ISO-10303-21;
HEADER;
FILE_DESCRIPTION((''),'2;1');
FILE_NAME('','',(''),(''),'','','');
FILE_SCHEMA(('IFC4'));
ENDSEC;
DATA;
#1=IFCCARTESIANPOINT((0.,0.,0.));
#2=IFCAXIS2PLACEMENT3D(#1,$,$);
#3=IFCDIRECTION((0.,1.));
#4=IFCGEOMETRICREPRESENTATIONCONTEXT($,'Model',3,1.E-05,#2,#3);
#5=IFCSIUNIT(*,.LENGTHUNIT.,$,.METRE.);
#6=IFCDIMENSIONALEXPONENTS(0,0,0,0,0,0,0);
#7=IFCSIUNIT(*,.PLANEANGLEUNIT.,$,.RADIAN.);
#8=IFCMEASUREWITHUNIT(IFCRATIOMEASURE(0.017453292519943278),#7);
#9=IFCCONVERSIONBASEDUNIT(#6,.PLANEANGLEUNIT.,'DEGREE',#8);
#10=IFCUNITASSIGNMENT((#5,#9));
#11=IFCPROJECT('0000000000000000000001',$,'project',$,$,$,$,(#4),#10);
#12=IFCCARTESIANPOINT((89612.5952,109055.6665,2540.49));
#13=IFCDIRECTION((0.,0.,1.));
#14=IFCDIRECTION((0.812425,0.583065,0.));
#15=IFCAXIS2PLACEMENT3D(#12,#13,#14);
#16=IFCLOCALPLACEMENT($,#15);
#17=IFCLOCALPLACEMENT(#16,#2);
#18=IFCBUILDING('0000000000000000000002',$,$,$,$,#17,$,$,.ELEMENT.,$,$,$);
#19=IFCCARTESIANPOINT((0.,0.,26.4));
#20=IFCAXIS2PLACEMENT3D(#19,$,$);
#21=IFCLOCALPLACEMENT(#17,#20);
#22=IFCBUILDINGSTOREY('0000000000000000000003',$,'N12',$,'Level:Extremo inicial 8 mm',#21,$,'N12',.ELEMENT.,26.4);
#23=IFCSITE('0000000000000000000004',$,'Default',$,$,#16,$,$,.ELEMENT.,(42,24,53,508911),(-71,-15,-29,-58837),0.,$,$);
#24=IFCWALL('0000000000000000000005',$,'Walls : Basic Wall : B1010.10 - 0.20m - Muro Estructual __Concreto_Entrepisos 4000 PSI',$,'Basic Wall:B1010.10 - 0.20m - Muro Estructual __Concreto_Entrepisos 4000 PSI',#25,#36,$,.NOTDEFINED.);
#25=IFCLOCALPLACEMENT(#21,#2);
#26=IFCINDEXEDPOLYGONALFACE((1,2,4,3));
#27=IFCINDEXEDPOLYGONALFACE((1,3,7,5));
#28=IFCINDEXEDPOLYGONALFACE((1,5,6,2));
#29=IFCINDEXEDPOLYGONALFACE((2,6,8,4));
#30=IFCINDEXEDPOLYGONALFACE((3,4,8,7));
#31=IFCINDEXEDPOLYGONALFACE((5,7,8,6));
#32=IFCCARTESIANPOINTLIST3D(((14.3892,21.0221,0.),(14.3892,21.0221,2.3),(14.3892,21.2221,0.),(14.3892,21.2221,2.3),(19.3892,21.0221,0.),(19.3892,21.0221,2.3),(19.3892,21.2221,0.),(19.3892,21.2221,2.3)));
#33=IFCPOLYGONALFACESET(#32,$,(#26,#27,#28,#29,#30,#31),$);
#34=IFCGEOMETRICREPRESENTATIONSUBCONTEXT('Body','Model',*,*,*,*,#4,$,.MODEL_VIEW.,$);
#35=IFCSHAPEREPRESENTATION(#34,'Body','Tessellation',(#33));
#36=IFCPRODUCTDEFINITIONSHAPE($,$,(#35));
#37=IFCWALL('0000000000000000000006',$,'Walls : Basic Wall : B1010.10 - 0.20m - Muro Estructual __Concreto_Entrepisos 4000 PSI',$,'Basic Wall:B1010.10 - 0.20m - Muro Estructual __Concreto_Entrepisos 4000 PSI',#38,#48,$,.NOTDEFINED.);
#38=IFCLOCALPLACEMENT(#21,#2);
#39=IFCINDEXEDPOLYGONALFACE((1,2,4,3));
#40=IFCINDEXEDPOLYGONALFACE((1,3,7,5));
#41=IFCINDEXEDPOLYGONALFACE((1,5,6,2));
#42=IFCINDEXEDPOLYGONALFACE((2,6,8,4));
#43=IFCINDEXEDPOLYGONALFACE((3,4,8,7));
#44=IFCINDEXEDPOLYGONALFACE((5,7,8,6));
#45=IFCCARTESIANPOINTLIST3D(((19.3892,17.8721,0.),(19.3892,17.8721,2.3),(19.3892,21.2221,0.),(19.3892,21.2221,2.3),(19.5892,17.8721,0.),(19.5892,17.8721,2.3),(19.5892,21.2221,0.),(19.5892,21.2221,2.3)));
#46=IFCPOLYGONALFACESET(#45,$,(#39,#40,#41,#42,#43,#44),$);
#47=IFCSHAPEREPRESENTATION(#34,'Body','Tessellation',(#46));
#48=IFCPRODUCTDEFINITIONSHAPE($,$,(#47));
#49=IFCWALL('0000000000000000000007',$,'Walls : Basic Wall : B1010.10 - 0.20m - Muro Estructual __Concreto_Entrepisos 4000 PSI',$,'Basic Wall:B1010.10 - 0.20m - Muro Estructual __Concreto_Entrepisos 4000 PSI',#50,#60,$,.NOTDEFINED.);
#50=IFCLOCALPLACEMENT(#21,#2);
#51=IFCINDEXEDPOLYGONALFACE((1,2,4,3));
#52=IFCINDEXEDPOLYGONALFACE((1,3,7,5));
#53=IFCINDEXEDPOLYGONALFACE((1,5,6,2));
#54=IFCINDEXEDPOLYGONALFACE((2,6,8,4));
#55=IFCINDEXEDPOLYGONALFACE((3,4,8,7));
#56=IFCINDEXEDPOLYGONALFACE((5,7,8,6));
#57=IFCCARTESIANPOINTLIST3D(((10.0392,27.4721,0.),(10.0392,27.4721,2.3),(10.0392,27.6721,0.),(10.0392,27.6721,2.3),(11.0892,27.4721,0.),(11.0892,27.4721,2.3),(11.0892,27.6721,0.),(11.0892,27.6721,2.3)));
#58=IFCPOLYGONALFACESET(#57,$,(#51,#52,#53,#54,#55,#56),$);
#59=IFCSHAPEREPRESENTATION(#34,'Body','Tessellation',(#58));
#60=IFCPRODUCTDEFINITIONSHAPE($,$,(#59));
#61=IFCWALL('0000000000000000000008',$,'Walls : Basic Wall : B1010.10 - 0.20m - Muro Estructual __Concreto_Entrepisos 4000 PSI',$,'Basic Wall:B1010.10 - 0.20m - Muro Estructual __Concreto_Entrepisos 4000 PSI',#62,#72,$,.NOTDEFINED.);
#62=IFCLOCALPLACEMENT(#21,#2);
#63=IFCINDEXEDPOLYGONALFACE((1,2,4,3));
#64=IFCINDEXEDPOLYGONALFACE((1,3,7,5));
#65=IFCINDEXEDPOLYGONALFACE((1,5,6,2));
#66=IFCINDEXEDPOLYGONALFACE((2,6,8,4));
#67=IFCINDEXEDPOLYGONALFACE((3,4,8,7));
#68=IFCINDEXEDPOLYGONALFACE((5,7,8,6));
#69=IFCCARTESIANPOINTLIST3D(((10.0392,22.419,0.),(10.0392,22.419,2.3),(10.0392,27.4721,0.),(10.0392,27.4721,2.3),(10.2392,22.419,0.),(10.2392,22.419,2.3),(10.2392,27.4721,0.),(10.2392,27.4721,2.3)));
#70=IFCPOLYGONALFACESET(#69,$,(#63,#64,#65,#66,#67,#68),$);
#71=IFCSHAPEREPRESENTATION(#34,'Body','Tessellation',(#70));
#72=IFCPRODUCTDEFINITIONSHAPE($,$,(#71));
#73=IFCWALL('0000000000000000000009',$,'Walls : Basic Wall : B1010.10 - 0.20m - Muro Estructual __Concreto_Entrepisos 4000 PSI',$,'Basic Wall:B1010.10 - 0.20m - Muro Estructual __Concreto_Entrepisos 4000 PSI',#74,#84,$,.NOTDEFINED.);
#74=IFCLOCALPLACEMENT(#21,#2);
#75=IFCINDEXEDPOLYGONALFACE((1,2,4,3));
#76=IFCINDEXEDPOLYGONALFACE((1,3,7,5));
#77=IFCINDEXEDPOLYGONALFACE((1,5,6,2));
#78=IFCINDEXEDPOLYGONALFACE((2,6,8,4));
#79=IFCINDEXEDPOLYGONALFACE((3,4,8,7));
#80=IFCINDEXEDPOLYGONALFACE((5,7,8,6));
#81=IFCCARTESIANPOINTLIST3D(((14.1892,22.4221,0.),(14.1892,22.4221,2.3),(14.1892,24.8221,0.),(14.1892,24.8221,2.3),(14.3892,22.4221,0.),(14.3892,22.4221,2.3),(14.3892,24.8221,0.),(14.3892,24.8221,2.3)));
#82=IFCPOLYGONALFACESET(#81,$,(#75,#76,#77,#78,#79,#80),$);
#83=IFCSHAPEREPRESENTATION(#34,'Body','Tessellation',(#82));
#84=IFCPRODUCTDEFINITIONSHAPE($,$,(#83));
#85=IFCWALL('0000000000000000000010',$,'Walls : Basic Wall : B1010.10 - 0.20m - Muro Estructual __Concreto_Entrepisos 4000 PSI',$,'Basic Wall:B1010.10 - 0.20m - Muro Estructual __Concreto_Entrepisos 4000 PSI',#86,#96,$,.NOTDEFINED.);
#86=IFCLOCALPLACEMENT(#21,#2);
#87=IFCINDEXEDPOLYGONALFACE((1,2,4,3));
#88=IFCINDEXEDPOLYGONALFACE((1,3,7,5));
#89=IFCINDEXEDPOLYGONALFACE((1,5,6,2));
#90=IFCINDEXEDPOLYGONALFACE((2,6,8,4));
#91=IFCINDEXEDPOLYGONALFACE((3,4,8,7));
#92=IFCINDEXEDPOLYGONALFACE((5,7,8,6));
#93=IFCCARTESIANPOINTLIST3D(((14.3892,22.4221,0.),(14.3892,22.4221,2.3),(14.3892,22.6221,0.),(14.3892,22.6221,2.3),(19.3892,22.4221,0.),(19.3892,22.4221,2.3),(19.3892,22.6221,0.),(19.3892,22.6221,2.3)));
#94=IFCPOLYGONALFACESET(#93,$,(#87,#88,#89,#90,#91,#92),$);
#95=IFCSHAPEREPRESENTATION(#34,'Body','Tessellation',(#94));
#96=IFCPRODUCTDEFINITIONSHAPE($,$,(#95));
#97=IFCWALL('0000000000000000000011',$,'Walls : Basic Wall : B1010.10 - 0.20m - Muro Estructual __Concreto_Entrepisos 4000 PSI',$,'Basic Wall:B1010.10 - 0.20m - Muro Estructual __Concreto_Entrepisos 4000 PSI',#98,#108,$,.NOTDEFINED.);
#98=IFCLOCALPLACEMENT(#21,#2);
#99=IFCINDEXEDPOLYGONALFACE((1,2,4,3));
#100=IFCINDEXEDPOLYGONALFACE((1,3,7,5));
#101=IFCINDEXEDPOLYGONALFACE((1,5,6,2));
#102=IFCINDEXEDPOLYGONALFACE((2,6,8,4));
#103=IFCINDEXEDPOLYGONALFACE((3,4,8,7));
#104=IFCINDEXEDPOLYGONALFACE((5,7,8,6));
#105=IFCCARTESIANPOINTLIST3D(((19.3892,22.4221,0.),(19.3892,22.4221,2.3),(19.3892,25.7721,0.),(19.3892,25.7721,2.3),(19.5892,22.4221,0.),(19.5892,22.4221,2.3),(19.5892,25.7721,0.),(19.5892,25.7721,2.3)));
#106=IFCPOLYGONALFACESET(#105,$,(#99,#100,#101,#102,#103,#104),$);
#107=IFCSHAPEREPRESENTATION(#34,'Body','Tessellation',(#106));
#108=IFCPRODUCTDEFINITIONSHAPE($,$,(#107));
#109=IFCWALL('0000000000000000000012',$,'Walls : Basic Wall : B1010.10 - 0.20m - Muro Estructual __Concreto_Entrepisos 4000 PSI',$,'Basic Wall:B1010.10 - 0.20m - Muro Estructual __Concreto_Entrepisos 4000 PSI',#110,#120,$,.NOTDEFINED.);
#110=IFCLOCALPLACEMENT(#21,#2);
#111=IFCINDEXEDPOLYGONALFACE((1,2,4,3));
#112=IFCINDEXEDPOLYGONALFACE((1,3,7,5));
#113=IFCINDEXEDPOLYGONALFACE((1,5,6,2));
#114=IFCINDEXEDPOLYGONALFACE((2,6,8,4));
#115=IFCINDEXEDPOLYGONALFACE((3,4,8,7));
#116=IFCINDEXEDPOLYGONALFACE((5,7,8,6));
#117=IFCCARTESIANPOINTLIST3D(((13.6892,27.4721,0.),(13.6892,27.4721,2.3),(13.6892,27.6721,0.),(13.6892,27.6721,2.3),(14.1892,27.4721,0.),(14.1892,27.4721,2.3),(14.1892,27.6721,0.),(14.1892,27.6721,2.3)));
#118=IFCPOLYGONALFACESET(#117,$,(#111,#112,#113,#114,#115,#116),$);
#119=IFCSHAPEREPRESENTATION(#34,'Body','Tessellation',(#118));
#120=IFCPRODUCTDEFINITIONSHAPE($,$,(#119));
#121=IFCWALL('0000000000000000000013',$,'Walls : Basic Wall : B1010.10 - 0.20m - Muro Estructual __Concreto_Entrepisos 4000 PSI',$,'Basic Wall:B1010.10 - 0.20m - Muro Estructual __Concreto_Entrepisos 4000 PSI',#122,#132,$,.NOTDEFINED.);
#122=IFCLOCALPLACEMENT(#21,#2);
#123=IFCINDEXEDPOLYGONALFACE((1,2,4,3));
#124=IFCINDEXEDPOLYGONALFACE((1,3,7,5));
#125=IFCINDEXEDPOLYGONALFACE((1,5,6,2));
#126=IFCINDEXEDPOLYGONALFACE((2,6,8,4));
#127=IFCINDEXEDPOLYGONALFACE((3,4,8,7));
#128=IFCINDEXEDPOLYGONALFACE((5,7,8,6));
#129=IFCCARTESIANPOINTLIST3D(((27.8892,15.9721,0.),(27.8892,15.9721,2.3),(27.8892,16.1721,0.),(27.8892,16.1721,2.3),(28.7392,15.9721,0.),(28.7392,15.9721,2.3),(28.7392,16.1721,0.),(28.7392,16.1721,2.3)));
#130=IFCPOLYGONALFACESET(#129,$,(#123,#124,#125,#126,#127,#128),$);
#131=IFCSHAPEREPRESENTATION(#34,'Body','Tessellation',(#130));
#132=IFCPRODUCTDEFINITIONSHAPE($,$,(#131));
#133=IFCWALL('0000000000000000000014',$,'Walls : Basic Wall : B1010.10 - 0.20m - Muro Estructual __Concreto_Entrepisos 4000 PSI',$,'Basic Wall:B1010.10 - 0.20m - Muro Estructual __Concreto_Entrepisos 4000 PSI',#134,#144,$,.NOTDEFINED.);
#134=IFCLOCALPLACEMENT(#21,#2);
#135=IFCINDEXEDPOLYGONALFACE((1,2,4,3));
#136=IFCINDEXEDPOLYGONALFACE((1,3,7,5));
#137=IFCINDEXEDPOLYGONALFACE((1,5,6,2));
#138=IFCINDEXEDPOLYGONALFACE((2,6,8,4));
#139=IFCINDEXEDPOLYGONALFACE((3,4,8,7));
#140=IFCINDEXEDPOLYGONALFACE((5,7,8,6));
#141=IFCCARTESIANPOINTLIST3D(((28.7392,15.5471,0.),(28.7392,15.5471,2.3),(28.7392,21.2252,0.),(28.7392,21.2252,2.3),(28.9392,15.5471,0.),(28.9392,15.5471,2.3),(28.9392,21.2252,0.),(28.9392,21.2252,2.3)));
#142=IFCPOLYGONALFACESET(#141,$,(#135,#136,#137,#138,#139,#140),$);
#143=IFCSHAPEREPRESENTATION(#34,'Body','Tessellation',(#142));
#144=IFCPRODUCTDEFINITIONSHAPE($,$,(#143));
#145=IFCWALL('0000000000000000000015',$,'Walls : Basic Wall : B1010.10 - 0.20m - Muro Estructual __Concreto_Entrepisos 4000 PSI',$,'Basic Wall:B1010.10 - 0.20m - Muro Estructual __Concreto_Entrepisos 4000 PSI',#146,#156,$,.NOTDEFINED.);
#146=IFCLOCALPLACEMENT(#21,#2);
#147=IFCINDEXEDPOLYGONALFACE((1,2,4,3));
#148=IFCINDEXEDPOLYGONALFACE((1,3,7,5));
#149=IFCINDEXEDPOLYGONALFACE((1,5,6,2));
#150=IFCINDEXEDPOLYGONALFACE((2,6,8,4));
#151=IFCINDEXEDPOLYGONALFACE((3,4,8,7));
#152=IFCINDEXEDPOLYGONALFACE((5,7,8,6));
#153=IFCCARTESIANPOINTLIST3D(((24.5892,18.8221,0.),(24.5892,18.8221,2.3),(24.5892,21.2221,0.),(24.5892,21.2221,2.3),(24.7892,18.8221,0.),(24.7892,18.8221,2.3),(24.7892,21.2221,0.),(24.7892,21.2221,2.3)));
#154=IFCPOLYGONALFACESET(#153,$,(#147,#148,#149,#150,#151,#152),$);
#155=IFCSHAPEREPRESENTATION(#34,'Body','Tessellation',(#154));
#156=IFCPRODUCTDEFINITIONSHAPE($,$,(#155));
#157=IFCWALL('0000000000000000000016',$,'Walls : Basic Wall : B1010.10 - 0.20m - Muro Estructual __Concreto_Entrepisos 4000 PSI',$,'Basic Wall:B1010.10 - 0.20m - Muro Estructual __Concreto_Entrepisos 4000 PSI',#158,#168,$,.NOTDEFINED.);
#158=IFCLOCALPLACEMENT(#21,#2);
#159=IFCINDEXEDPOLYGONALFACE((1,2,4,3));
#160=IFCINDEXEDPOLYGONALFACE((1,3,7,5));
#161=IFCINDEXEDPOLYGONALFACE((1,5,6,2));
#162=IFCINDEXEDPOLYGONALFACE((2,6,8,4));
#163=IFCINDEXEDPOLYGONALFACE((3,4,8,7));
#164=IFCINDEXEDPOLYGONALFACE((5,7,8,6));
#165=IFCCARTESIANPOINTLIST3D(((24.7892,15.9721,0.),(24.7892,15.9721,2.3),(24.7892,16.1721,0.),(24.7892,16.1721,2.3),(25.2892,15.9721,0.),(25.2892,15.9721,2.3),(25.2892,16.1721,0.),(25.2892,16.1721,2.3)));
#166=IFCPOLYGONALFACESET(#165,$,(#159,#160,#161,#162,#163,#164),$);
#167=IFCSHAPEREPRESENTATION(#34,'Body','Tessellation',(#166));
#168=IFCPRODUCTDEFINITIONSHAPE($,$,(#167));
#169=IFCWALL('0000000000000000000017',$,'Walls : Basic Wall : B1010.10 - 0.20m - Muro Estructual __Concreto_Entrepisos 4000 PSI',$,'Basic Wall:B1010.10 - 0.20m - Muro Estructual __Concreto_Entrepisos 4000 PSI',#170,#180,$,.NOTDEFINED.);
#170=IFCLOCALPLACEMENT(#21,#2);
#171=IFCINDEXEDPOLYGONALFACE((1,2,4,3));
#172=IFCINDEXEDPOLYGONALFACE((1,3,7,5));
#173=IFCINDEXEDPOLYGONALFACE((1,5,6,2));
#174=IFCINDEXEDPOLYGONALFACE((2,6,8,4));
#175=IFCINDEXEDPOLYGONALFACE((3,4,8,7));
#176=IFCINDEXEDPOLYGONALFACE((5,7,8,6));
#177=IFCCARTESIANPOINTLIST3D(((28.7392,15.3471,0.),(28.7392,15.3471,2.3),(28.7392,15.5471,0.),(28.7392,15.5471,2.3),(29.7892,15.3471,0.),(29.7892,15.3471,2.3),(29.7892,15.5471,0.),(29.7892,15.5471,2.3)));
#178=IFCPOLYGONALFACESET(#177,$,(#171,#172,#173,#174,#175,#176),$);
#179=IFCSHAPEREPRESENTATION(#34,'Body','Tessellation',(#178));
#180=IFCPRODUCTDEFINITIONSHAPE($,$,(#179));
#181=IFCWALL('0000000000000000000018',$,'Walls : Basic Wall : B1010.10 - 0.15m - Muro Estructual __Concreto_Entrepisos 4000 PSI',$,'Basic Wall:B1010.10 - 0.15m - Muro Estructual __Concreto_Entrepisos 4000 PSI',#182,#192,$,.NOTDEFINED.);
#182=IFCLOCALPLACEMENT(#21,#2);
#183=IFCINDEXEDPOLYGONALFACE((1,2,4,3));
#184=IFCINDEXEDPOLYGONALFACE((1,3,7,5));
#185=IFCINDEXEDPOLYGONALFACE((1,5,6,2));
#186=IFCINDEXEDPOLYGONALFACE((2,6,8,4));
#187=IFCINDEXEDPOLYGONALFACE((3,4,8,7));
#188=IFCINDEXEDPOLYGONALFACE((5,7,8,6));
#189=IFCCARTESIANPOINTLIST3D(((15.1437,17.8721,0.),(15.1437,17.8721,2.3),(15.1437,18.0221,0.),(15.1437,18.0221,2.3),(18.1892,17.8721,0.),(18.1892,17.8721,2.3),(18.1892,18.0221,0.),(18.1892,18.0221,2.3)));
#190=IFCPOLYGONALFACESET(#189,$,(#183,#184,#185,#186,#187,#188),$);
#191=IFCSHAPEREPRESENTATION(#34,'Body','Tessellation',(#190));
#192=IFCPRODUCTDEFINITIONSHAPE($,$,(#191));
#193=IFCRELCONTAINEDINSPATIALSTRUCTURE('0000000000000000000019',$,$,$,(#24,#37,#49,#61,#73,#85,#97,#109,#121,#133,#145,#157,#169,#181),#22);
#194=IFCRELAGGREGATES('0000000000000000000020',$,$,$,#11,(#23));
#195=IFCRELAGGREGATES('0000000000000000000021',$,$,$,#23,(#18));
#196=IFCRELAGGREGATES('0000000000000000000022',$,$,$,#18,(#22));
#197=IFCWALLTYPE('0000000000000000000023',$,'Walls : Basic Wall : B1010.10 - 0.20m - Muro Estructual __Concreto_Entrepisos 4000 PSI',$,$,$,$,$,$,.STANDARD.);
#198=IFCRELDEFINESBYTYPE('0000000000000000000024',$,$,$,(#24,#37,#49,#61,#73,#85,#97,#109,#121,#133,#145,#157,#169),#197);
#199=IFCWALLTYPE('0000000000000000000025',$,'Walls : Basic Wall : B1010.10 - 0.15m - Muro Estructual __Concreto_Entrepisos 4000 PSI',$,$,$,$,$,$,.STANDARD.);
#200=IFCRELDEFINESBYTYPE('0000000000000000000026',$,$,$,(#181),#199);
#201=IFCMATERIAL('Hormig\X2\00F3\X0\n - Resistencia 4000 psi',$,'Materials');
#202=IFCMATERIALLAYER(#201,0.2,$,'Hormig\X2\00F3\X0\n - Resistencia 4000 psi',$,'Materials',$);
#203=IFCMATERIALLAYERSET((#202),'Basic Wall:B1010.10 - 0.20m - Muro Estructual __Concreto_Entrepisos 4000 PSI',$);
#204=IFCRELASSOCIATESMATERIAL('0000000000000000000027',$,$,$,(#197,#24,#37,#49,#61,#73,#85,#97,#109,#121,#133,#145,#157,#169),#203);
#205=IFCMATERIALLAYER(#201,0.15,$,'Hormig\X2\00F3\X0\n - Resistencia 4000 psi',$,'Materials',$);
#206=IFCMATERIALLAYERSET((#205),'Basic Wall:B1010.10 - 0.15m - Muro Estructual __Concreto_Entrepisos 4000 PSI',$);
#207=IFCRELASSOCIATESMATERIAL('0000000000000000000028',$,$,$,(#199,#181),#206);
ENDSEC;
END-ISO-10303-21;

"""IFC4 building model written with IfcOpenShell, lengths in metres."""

from ifc_helpers import new_model, entity, si_unit, converted_unit, direction, frame, frame_2d, origin, place, context, subcontext, project, spatial, rectangle, extrude, material, layer, layer_set, layer_usage, type_object, element, save


model = new_model("IFC4")

# Units and contexts
model_context = context("Model", 3, precision=1e-05, world=origin(), true_north=direction((0.0, 1.0)))
body_context = subcontext(model_context, "Body", "Model", "MODEL_VIEW")
ifc_project = project(units=[si_unit("LENGTHUNIT", "METRE"), converted_unit("PLANEANGLEUNIT", "DEGREE", entity("IfcRatioMeasure", 0.017453292519943278), si_unit("PLANEANGLEUNIT", "RADIAN"), dimensions=[0, 0, 0, 0, 0, 0, 0])], contexts=[model_context])

# Site, building, storey
site_placement = place(None, frame((89612.5952, 109055.6665, 2540.49), z_axis=(0.0, 0.0, 1.0), x_axis=(0.812425, 0.583065, 0.0)))
site = spatial("IfcSite", under=ifc_project, at=site_placement, Name="Default", CompositionType="ELEMENT", RefLatitude=(42, 24, 53, 508911), RefLongitude=(-71, -15, -29, -58837), RefElevation=0.0)
building_placement = place(site_placement, origin())
building = spatial("IfcBuilding", under=site, at=building_placement, CompositionType="ELEMENT")
storey_placement = place(building_placement, frame((0.0, 0.0, 26.4)))
storey = spatial("IfcBuildingStorey", under=building, at=storey_placement, Name="N12", ObjectType="Level:Extremo inicial 8 mm", LongName="N12", CompositionType="ELEMENT", Elevation=26.4)

# Walls
ifc_material = material(Name="Hormigón - Resistencia 4000 psi", Category="Materials")
ifc_layer_1 = layer(ifc_material, 0.2, Name="Hormigón - Resistencia 4000 psi", Category="Materials")
ifc_layer_set_1 = layer_set([ifc_layer_1], Name="Basic Wall:B1010.10 - 0.20m - Muro Estructual __Concreto_Entrepisos 4000 PSI")
ifc_layer_usage_1 = layer_usage(ifc_layer_set_1, "AXIS2", "NEGATIVE", 0.1)
wall_type_1 = type_object("IfcWallType", Name="Walls : Basic Wall : B1010.10 - 0.20m - Muro Estructual __Concreto_Entrepisos 4000 PSI", PredefinedType="STANDARD", material=ifc_layer_set_1)
wall_1_placement = place(storey_placement, frame((14.3892, 21.1221, 0.0)))
element("IfcWall", 1, at=wall_1_placement, inside=storey, type_object=wall_type_1, material=ifc_layer_usage_1, Name="Walls : Basic Wall : B1010.10 - 0.20m - Muro Estructual __Concreto_Entrepisos 4000 PSI", ObjectType="Basic Wall:B1010.10 - 0.20m - Muro Estructual __Concreto_Entrepisos 4000 PSI", PredefinedType="NOTDEFINED", context=body_context, shape_type="SweptSolid", body=[
    extrude(rectangle(XDim=5.0, YDim=0.2, at=frame_2d((2.5, 0.0), x_axis=(-1.0, 0.0))), origin(), (0.0, 0.0, 1.0), 2.3),
])
ifc_layer_usage_2 = layer_usage(ifc_layer_set_1, "AXIS2", "NEGATIVE", 0.1)
wall_2_placement = place(storey_placement, frame((19.4892, 21.2221, 0.0), z_axis=(0.0, 0.0, 1.0), x_axis=(0.0, -1.0, 0.0)))
element("IfcWall", 2, at=wall_2_placement, inside=storey, type_object=wall_type_1, material=ifc_layer_usage_2, Name="Walls : Basic Wall : B1010.10 - 0.20m - Muro Estructual __Concreto_Entrepisos 4000 PSI", ObjectType="Basic Wall:B1010.10 - 0.20m - Muro Estructual __Concreto_Entrepisos 4000 PSI", PredefinedType="NOTDEFINED", context=body_context, shape_type="SweptSolid", body=[
    extrude(rectangle(XDim=3.35, YDim=0.2, at=frame_2d((1.675, 0.0), x_axis=(-1.0, 0.0))), origin(), (0.0, 0.0, 1.0), 2.3),
])
ifc_layer_usage_3 = layer_usage(ifc_layer_set_1, "AXIS2", "POSITIVE", -0.1)
wall_3_placement = place(storey_placement, frame((11.0892, 27.5721, 0.0), z_axis=(0.0, 0.0, 1.0), x_axis=(-1.0, 0.0, 0.0)))
element("IfcWall", 3, at=wall_3_placement, inside=storey, type_object=wall_type_1, material=ifc_layer_usage_3, Name="Walls : Basic Wall : B1010.10 - 0.20m - Muro Estructual __Concreto_Entrepisos 4000 PSI", ObjectType="Basic Wall:B1010.10 - 0.20m - Muro Estructual __Concreto_Entrepisos 4000 PSI", PredefinedType="NOTDEFINED", context=body_context, shape_type="SweptSolid", body=[
    extrude(rectangle(XDim=1.05, YDim=0.2, at=frame_2d((0.525, 0.0), x_axis=(-1.0, 0.0))), origin(), (0.0, 0.0, 1.0), 2.3),
])
ifc_layer_usage_4 = layer_usage(ifc_layer_set_1, "AXIS2", "POSITIVE", -0.1)
wall_4_placement = place(storey_placement, frame((10.1392, 27.4721, 0.0), z_axis=(0.0, 0.0, 1.0), x_axis=(0.0, -1.0, 0.0)))
element("IfcWall", 4, at=wall_4_placement, inside=storey, type_object=wall_type_1, material=ifc_layer_usage_4, Name="Walls : Basic Wall : B1010.10 - 0.20m - Muro Estructual __Concreto_Entrepisos 4000 PSI", ObjectType="Basic Wall:B1010.10 - 0.20m - Muro Estructual __Concreto_Entrepisos 4000 PSI", PredefinedType="NOTDEFINED", context=body_context, shape_type="SweptSolid", body=[
    extrude(rectangle(XDim=5.0531, YDim=0.2, at=frame_2d((2.5265, 0.0), x_axis=(-1.0, 0.0))), origin(), (0.0, 0.0, 1.0), 2.3),
])
ifc_layer_usage_5 = layer_usage(ifc_layer_set_1, "AXIS2", "POSITIVE", -0.1)
wall_5_placement = place(storey_placement, frame((14.2892, 24.8221, 0.0), z_axis=(0.0, 0.0, 1.0), x_axis=(0.0, -1.0, 0.0)))
element("IfcWall", 5, at=wall_5_placement, inside=storey, type_object=wall_type_1, material=ifc_layer_usage_5, Name="Walls : Basic Wall : B1010.10 - 0.20m - Muro Estructual __Concreto_Entrepisos 4000 PSI", ObjectType="Basic Wall:B1010.10 - 0.20m - Muro Estructual __Concreto_Entrepisos 4000 PSI", PredefinedType="NOTDEFINED", context=body_context, shape_type="SweptSolid", body=[
    extrude(rectangle(XDim=2.4, YDim=0.2, at=frame_2d((1.2, 0.0), x_axis=(-1.0, 0.0))), origin(), (0.0, 0.0, 1.0), 2.3),
])
ifc_layer_usage_6 = layer_usage(ifc_layer_set_1, "AXIS2", "POSITIVE", -0.1)
wall_6_placement = place(storey_placement, frame((14.3892, 22.5221, 0.0)))
element("IfcWall", 6, at=wall_6_placement, inside=storey, type_object=wall_type_1, material=ifc_layer_usage_6, Name="Walls : Basic Wall : B1010.10 - 0.20m - Muro Estructual __Concreto_Entrepisos 4000 PSI", ObjectType="Basic Wall:B1010.10 - 0.20m - Muro Estructual __Concreto_Entrepisos 4000 PSI", PredefinedType="NOTDEFINED", context=body_context, shape_type="SweptSolid", body=[
    extrude(rectangle(XDim=5.0, YDim=0.2, at=frame_2d((2.5, 0.0), x_axis=(-1.0, 0.0))), origin(), (0.0, 0.0, 1.0), 2.3),
])
ifc_layer_usage_7 = layer_usage(ifc_layer_set_1, "AXIS2", "POSITIVE", -0.1)
wall_7_placement = place(storey_placement, frame((19.4892, 22.4221, 0.0), z_axis=(0.0, 0.0, 1.0), x_axis=(0.0, 1.0, 0.0)))
element("IfcWall", 7, at=wall_7_placement, inside=storey, type_object=wall_type_1, material=ifc_layer_usage_7, Name="Walls : Basic Wall : B1010.10 - 0.20m - Muro Estructual __Concreto_Entrepisos 4000 PSI", ObjectType="Basic Wall:B1010.10 - 0.20m - Muro Estructual __Concreto_Entrepisos 4000 PSI", PredefinedType="NOTDEFINED", context=body_context, shape_type="SweptSolid", body=[
    extrude(rectangle(XDim=3.35, YDim=0.2, at=frame_2d((1.675, 0.0), x_axis=(-1.0, 0.0))), origin(), (0.0, 0.0, 1.0), 2.3),
])
ifc_layer_usage_8 = layer_usage(ifc_layer_set_1, "AXIS2", "POSITIVE", -0.1)
wall_8_placement = place(storey_placement, frame((13.6892, 27.5721, 0.0)))
element("IfcWall", 8, at=wall_8_placement, inside=storey, type_object=wall_type_1, material=ifc_layer_usage_8, Name="Walls : Basic Wall : B1010.10 - 0.20m - Muro Estructual __Concreto_Entrepisos 4000 PSI", ObjectType="Basic Wall:B1010.10 - 0.20m - Muro Estructual __Concreto_Entrepisos 4000 PSI", PredefinedType="NOTDEFINED", context=body_context, shape_type="SweptSolid", body=[
    extrude(rectangle(XDim=0.5, YDim=0.2, at=frame_2d((0.25, 0.0), x_axis=(-1.0, 0.0))), origin(), (0.0, 0.0, 1.0), 2.3),
])
ifc_layer_usage_9 = layer_usage(ifc_layer_set_1, "AXIS2", "POSITIVE", -0.1)
wall_9_placement = place(storey_placement, frame((27.8892, 16.0721, 0.0)))
element("IfcWall", 9, at=wall_9_placement, inside=storey, type_object=wall_type_1, material=ifc_layer_usage_9, Name="Walls : Basic Wall : B1010.10 - 0.20m - Muro Estructual __Concreto_Entrepisos 4000 PSI", ObjectType="Basic Wall:B1010.10 - 0.20m - Muro Estructual __Concreto_Entrepisos 4000 PSI", PredefinedType="NOTDEFINED", context=body_context, shape_type="SweptSolid", body=[
    extrude(rectangle(XDim=0.85, YDim=0.2, at=frame_2d((0.425, 0.0), x_axis=(-1.0, 0.0))), origin(), (0.0, 0.0, 1.0), 2.3),
])
ifc_layer_usage_10 = layer_usage(ifc_layer_set_1, "AXIS2", "POSITIVE", -0.1)
wall_10_placement = place(storey_placement, frame((28.8392, 15.5471, 0.0), z_axis=(0.0, 0.0, 1.0), x_axis=(0.0, 1.0, 0.0)))
element("IfcWall", 10, at=wall_10_placement, inside=storey, type_object=wall_type_1, material=ifc_layer_usage_10, Name="Walls : Basic Wall : B1010.10 - 0.20m - Muro Estructual __Concreto_Entrepisos 4000 PSI", ObjectType="Basic Wall:B1010.10 - 0.20m - Muro Estructual __Concreto_Entrepisos 4000 PSI", PredefinedType="NOTDEFINED", context=body_context, shape_type="SweptSolid", body=[
    extrude(rectangle(XDim=5.6781, YDim=0.2, at=frame_2d((2.839, 0.0), x_axis=(-1.0, 0.0))), origin(), (0.0, 0.0, 1.0), 2.3),
])
ifc_layer_usage_11 = layer_usage(ifc_layer_set_1, "AXIS2", "POSITIVE", -0.1)
wall_11_placement = place(storey_placement, frame((24.6892, 18.8221, 0.0), z_axis=(0.0, 0.0, 1.0), x_axis=(0.0, 1.0, 0.0)))
element("IfcWall", 11, at=wall_11_placement, inside=storey, type_object=wall_type_1, material=ifc_layer_usage_11, Name="Walls : Basic Wall : B1010.10 - 0.20m - Muro Estructual __Concreto_Entrepisos 4000 PSI", ObjectType="Basic Wall:B1010.10 - 0.20m - Muro Estructual __Concreto_Entrepisos 4000 PSI", PredefinedType="NOTDEFINED", context=body_context, shape_type="SweptSolid", body=[
    extrude(rectangle(XDim=2.4, YDim=0.2, at=frame_2d((1.2, 0.0), x_axis=(-1.0, 0.0))), origin(), (0.0, 0.0, 1.0), 2.3),
])
ifc_layer_usage_12 = layer_usage(ifc_layer_set_1, "AXIS2", "POSITIVE", -0.1)
wall_12_placement = place(storey_placement, frame((25.2892, 16.0721, 0.0), z_axis=(0.0, 0.0, 1.0), x_axis=(-1.0, 0.0, 0.0)))
element("IfcWall", 12, at=wall_12_placement, inside=storey, type_object=wall_type_1, material=ifc_layer_usage_12, Name="Walls : Basic Wall : B1010.10 - 0.20m - Muro Estructual __Concreto_Entrepisos 4000 PSI", ObjectType="Basic Wall:B1010.10 - 0.20m - Muro Estructual __Concreto_Entrepisos 4000 PSI", PredefinedType="NOTDEFINED", context=body_context, shape_type="SweptSolid", body=[
    extrude(rectangle(XDim=0.5, YDim=0.2, at=frame_2d((0.25, 0.0), x_axis=(-1.0, 0.0))), origin(), (0.0, 0.0, 1.0), 2.3),
])
ifc_layer_usage_13 = layer_usage(ifc_layer_set_1, "AXIS2", "NEGATIVE", 0.1)
wall_13_placement = place(storey_placement, frame((29.7892, 15.4471, 0.0), z_axis=(0.0, 0.0, 1.0), x_axis=(-1.0, 0.0, 0.0)))
element("IfcWall", 13, at=wall_13_placement, inside=storey, type_object=wall_type_1, material=ifc_layer_usage_13, Name="Walls : Basic Wall : B1010.10 - 0.20m - Muro Estructual __Concreto_Entrepisos 4000 PSI", ObjectType="Basic Wall:B1010.10 - 0.20m - Muro Estructual __Concreto_Entrepisos 4000 PSI", PredefinedType="NOTDEFINED", context=body_context, shape_type="SweptSolid", body=[
    extrude(rectangle(XDim=1.05, YDim=0.2, at=frame_2d((0.525, 0.0), x_axis=(-1.0, 0.0))), origin(), (0.0, 0.0, 1.0), 2.3),
])
ifc_layer_2 = layer(ifc_material, 0.15, Name="Hormigón - Resistencia 4000 psi", Category="Materials")
ifc_layer_set_2 = layer_set([ifc_layer_2], Name="Basic Wall:B1010.10 - 0.15m - Muro Estructual __Concreto_Entrepisos 4000 PSI")
ifc_layer_usage_14 = layer_usage(ifc_layer_set_2, "AXIS2", "NEGATIVE", 0.075)
wall_type_2 = type_object("IfcWallType", Name="Walls : Basic Wall : B1010.10 - 0.15m - Muro Estructual __Concreto_Entrepisos 4000 PSI", PredefinedType="STANDARD", material=ifc_layer_set_2)
wall_14_placement = place(storey_placement, frame((18.1892, 17.9471, 0.0), z_axis=(0.0, 0.0, 1.0), x_axis=(-1.0, 0.0, 0.0)))
element("IfcWall", 14, at=wall_14_placement, inside=storey, type_object=wall_type_2, material=ifc_layer_usage_14, Name="Walls : Basic Wall : B1010.10 - 0.15m - Muro Estructual __Concreto_Entrepisos 4000 PSI", ObjectType="Basic Wall:B1010.10 - 0.15m - Muro Estructual __Concreto_Entrepisos 4000 PSI", PredefinedType="NOTDEFINED", context=body_context, shape_type="SweptSolid", body=[
    extrude(rectangle(XDim=3.0455, YDim=0.15, at=frame_2d((1.5228, 0.0), x_axis=(-1.0, 0.0))), origin(), (0.0, 0.0, 1.0), 2.3),
])

save(model, "model.ifc")
